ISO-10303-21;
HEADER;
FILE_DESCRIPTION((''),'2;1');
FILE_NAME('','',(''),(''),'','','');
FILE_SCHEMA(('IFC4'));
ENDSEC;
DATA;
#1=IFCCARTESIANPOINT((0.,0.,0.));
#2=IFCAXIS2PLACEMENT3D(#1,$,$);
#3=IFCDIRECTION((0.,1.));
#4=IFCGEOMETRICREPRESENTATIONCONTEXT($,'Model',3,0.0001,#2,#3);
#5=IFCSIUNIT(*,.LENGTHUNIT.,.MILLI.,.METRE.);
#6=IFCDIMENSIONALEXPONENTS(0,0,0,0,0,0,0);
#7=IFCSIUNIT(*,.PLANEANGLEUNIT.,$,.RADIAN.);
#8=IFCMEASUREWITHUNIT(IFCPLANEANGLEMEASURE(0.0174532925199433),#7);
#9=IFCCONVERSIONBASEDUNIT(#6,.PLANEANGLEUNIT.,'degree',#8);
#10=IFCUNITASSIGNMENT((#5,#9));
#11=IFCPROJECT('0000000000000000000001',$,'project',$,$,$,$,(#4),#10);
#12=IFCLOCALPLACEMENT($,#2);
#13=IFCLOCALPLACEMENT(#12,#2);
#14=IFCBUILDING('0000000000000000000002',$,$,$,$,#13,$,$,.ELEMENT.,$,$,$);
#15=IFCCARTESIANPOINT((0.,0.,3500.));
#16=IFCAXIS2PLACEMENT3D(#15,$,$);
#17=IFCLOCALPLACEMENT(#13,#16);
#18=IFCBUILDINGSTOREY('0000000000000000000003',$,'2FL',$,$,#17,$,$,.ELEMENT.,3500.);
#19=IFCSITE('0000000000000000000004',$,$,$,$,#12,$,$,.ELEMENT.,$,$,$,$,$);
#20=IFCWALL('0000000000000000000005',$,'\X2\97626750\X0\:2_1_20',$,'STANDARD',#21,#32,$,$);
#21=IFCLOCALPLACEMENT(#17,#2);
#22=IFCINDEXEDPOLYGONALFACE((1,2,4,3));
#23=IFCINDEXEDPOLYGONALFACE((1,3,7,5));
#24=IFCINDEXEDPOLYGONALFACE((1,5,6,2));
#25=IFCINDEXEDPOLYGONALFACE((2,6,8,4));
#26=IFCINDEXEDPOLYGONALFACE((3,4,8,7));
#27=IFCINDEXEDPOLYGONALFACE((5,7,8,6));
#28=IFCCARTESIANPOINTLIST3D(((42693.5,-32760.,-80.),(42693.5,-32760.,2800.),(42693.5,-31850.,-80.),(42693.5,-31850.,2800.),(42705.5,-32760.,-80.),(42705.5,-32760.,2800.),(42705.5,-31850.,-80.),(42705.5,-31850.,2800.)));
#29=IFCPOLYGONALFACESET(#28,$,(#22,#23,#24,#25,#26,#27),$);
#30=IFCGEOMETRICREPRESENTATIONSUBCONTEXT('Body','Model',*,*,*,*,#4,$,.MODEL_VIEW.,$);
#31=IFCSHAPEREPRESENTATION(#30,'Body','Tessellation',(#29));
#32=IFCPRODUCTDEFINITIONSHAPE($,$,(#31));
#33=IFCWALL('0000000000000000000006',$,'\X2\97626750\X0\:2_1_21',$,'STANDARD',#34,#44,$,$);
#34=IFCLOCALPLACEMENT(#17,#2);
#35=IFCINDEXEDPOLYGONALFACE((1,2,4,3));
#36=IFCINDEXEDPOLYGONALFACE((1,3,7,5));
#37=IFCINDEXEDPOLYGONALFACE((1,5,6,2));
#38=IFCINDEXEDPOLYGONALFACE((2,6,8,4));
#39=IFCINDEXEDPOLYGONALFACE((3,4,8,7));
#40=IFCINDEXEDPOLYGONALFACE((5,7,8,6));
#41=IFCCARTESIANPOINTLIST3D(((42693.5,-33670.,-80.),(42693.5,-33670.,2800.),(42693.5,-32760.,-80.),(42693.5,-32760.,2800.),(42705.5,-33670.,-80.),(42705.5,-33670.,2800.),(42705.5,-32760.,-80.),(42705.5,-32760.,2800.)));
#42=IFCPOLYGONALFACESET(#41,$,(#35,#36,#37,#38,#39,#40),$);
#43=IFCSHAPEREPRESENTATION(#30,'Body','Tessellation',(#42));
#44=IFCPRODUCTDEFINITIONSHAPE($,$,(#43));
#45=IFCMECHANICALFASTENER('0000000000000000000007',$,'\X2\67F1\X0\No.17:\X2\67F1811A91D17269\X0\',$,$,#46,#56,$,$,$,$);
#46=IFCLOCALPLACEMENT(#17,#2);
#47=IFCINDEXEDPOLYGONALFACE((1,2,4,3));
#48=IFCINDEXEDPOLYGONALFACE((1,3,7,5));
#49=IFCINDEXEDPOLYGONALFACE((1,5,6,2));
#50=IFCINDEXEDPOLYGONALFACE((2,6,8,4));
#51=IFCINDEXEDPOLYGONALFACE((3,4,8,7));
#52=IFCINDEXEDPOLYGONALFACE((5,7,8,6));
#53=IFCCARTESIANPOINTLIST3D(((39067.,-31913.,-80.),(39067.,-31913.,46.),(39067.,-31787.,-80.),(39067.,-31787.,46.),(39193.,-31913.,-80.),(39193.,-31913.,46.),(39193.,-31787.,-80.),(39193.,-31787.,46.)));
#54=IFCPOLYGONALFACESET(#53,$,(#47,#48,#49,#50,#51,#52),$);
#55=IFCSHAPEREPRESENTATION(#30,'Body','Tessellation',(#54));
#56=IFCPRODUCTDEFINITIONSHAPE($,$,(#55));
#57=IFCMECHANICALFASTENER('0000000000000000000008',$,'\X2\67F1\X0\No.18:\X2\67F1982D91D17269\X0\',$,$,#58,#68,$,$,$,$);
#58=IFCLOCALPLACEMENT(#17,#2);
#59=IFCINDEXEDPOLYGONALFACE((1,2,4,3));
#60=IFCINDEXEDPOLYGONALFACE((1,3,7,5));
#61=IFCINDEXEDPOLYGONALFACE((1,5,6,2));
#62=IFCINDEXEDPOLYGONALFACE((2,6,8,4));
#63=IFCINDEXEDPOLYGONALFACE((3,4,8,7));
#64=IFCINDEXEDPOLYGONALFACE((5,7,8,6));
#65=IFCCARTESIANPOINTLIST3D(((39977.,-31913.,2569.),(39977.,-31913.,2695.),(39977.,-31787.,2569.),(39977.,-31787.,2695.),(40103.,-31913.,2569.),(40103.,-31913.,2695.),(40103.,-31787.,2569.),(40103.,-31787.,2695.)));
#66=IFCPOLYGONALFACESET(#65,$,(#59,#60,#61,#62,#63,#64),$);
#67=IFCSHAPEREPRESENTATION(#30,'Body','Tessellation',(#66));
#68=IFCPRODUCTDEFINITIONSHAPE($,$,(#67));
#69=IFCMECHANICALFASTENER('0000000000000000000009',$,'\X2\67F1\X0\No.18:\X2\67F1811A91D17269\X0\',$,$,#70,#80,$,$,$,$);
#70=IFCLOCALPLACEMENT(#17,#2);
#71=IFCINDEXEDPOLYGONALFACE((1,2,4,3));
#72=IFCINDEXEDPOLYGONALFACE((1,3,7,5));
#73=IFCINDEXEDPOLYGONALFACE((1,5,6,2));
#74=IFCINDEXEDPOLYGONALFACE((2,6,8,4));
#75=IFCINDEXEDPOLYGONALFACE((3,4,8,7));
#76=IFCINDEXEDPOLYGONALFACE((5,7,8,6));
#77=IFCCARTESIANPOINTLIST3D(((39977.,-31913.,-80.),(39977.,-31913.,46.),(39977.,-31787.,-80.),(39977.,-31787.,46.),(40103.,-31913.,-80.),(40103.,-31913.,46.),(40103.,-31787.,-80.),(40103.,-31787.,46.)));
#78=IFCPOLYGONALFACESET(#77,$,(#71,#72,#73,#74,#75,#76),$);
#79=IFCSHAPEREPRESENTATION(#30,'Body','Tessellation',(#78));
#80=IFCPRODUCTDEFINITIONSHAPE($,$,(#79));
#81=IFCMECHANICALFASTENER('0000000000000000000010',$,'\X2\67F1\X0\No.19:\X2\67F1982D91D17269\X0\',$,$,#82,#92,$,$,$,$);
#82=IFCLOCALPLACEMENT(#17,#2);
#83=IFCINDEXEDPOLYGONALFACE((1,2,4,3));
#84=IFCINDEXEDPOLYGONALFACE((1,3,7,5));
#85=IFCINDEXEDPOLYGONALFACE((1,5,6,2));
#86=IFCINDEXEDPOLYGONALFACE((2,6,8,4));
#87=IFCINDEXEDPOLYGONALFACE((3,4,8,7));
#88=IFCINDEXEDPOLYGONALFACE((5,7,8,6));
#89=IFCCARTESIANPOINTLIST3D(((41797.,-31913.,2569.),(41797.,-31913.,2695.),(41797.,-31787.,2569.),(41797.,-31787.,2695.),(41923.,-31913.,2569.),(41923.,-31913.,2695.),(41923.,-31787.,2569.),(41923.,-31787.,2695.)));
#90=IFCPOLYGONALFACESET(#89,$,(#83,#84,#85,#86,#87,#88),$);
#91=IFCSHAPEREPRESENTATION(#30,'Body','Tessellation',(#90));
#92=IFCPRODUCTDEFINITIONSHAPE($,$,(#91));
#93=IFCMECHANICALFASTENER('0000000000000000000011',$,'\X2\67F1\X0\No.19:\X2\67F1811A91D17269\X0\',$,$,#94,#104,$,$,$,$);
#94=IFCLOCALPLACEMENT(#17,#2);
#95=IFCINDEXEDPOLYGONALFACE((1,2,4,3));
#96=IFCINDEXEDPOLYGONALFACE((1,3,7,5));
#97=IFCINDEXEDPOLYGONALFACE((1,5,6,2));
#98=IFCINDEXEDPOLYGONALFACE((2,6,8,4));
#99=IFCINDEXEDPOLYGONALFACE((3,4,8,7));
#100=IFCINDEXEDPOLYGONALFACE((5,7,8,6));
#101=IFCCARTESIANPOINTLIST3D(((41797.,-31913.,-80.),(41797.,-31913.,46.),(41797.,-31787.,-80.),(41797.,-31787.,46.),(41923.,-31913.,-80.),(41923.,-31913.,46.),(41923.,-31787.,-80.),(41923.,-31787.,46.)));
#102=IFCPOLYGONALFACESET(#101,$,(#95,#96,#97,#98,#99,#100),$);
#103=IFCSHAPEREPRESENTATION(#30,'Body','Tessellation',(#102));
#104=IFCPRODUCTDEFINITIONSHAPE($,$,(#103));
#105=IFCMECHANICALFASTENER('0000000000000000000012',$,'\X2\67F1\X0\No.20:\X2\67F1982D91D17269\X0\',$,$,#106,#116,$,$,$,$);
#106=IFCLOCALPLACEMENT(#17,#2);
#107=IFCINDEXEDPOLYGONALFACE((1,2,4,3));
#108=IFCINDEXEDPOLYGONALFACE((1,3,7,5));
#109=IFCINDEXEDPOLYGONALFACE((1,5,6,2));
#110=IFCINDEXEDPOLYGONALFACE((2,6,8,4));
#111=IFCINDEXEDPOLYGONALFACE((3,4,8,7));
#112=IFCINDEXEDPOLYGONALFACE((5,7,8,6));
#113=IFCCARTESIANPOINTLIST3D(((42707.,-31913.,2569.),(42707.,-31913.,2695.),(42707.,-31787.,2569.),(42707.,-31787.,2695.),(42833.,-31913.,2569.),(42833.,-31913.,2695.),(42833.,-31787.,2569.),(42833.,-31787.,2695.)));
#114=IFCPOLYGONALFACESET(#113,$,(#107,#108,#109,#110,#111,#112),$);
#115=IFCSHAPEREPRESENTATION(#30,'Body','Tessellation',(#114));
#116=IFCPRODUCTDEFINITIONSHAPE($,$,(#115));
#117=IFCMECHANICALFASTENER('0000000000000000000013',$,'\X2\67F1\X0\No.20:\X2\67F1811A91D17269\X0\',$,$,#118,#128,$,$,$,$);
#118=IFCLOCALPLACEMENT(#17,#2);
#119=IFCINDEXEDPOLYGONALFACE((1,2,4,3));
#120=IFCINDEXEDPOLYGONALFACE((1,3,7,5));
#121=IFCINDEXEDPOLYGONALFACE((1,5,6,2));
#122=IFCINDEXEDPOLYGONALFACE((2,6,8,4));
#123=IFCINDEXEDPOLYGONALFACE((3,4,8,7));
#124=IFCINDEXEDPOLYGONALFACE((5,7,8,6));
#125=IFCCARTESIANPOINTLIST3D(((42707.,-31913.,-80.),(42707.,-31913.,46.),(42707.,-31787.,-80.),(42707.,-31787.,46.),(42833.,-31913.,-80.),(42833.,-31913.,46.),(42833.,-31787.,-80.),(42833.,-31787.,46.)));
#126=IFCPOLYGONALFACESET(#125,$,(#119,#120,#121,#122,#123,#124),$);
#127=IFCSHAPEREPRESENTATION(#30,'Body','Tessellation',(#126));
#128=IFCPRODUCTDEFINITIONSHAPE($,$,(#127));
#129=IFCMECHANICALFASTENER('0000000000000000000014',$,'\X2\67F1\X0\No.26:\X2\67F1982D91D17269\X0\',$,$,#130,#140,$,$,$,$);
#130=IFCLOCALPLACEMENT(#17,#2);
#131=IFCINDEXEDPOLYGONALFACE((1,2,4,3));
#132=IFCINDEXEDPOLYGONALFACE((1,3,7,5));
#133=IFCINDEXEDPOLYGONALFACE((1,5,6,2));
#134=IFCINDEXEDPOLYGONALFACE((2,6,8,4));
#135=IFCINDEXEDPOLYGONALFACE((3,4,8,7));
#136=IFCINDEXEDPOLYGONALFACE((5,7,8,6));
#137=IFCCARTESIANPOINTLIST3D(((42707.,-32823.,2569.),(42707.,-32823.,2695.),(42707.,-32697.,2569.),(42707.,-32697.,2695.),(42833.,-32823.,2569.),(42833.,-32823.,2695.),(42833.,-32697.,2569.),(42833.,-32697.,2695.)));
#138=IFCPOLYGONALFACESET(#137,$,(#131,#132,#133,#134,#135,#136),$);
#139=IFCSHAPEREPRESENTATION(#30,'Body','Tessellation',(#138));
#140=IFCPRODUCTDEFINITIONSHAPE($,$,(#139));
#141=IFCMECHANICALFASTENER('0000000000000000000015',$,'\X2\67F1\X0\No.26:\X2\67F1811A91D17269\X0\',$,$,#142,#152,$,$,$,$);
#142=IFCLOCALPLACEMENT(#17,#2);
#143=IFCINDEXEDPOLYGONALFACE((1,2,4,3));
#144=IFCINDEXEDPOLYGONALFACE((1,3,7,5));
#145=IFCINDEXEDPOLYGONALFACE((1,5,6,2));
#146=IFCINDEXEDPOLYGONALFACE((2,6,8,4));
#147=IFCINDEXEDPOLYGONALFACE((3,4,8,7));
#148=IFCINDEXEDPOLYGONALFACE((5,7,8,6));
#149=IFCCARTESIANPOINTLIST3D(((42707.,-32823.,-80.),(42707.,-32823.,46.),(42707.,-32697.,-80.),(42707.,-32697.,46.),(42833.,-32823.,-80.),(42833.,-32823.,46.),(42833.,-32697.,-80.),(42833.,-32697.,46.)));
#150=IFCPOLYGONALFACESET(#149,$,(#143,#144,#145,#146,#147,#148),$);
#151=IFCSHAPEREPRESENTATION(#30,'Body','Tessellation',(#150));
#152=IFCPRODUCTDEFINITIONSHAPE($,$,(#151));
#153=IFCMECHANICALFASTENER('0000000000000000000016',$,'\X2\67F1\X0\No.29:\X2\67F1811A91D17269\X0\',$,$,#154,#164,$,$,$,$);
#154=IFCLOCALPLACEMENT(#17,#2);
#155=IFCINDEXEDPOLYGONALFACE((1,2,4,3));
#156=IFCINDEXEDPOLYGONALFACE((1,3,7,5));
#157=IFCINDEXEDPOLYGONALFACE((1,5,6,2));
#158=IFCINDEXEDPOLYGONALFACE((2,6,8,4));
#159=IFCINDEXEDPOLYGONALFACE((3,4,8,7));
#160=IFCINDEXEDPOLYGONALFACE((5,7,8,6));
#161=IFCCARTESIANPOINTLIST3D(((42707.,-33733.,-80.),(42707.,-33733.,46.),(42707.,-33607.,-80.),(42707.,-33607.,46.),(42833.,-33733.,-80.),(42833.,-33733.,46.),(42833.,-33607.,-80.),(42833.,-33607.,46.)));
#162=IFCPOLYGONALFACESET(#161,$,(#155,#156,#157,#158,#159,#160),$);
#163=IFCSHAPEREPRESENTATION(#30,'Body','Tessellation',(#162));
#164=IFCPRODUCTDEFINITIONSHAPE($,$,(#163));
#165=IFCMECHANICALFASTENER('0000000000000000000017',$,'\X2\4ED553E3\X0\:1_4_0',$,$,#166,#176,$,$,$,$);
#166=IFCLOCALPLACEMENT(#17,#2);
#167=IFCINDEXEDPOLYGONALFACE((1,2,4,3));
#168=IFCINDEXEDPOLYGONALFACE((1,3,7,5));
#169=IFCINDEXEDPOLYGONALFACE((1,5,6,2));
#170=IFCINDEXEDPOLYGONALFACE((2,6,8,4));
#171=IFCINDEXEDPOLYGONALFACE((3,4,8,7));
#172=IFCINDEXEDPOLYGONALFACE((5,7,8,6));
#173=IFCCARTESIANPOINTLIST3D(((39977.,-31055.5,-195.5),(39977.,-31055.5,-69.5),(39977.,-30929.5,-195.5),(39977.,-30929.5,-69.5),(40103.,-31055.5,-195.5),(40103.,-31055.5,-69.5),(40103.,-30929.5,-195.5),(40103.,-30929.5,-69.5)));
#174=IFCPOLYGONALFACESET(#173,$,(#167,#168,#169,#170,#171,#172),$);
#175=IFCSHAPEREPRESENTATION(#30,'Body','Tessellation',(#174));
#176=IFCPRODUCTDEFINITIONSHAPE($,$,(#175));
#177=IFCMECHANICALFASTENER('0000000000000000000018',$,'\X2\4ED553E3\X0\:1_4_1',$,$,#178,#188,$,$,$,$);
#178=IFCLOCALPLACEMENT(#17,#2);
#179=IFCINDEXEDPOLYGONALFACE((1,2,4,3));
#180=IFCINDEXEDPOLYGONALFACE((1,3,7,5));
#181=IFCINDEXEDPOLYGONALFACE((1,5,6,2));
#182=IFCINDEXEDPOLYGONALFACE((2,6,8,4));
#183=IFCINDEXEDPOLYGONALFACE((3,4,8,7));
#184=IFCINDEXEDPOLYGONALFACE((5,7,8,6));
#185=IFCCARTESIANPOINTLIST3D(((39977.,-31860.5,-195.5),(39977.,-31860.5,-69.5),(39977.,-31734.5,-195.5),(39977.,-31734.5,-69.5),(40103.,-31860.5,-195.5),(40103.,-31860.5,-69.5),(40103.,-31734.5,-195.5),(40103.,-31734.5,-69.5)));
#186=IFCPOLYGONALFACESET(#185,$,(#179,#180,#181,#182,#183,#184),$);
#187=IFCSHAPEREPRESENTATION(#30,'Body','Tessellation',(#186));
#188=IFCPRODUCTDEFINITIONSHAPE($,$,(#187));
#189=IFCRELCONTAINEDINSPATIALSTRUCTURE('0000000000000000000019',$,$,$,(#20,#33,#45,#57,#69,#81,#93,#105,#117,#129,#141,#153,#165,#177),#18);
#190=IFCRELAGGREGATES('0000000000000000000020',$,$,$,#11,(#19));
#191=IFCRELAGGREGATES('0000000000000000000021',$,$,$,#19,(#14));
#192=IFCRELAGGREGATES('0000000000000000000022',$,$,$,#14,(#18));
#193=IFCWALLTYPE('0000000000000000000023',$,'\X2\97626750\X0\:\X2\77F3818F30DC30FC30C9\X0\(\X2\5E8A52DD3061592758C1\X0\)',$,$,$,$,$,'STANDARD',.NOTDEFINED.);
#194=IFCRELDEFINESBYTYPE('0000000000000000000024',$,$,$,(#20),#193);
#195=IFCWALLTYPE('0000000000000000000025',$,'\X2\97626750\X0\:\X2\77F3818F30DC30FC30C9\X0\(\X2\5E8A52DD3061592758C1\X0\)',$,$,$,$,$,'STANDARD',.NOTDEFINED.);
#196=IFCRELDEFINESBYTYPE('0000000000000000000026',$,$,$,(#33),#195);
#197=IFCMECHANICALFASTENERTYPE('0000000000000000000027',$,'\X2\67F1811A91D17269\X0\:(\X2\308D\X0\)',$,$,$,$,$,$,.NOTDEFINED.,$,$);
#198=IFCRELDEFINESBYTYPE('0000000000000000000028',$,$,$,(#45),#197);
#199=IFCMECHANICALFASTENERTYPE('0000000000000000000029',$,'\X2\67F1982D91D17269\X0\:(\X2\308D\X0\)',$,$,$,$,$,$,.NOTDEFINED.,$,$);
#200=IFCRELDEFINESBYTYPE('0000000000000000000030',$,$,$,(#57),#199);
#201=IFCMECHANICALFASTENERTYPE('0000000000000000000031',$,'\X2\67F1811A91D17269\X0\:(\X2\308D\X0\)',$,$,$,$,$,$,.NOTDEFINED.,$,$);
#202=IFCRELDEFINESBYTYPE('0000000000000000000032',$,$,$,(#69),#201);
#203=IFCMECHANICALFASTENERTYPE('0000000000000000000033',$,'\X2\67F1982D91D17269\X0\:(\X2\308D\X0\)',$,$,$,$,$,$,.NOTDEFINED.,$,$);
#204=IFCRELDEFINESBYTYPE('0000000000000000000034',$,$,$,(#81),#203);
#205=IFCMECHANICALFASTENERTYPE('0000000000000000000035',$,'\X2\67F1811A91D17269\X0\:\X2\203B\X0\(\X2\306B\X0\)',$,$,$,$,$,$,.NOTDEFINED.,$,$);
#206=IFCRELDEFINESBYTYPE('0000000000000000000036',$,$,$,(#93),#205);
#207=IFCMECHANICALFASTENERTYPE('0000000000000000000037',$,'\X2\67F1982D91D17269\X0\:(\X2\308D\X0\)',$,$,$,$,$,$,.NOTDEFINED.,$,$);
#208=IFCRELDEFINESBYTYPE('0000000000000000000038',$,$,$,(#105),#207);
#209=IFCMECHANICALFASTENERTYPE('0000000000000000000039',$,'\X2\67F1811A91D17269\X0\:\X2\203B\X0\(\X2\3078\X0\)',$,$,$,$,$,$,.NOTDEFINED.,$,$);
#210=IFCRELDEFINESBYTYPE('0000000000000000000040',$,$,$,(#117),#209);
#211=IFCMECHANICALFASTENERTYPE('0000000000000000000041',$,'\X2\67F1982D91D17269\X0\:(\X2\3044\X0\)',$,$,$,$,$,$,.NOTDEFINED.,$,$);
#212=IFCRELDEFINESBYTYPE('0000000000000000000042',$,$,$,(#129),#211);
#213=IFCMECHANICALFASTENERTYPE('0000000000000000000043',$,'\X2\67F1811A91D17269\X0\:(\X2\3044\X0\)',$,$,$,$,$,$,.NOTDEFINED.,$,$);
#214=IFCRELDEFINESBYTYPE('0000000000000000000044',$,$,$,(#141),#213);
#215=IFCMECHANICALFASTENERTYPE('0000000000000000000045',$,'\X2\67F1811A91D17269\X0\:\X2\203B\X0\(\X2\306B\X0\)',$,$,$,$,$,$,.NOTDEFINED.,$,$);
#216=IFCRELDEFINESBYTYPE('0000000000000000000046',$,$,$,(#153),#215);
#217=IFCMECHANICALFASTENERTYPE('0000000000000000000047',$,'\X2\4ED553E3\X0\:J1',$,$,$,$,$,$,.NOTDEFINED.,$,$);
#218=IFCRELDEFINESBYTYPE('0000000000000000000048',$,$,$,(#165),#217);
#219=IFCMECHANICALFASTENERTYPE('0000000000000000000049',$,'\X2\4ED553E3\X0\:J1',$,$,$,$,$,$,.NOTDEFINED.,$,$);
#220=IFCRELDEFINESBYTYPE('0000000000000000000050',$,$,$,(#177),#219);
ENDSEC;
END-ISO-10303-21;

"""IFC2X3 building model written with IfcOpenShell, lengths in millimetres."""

from ifc_helpers import new_model, entity, si_unit, converted_unit, direction, frame, origin, origin_with_axes, origin_2d, place, context, subcontext, project, spatial, polyline, rectangle, outline, extrude, type_object, element, save


model = new_model("IFC2X3")

# Units and contexts
model_context = context("Model", 3, precision=0.0001, world=origin(), true_north=direction((0.0, 1.0)))
body_context = subcontext(model_context, "Body", "Model", "MODEL_VIEW")
ifc_project = project(units=[si_unit("LENGTHUNIT", "METRE", prefix="MILLI"), converted_unit("PLANEANGLEUNIT", "degree", entity("IfcPlaneAngleMeasure", 0.0174532925199433), si_unit("PLANEANGLEUNIT", "RADIAN"), dimensions=[0, 0, 0, 0, 0, 0, 0])], contexts=[model_context])

# Site, building, storey
site_placement = place(None, origin())
site = spatial("IfcSite", under=ifc_project, at=site_placement, CompositionType="ELEMENT")
building_placement = place(site_placement, origin())
building = spatial("IfcBuilding", under=site, at=building_placement, CompositionType="ELEMENT")
storey_placement = place(building_placement, frame((0.0, 0.0, 3500.0)))
storey = spatial("IfcBuildingStorey", under=building, at=storey_placement, Name="2FL", CompositionType="ELEMENT", Elevation=3500.0)

# Walls
wall_type_1 = type_object("IfcWallType", Name="面材:石膏ボード(床勝ち大壁)", ElementType="STANDARD", PredefinedType="NOTDEFINED")
wall_1_placement = place(storey_placement, frame((42705.5, -32305.0, -80.0), z_axis=(-1.0, 0.0, 0.0), x_axis=(0.0, -1.0, 0.0)))
element("IfcWall", 1, at=wall_1_placement, inside=storey, type_object=wall_type_1, Name="面材:2_1_20", ObjectType="STANDARD", context=body_context, shape_type="SweptSolid", body=[
    extrude(outline(polyline([(455.0, 0.0, 0.0), (-455.0, 0.0, 0.0), (-455.0, 2880.0, 0.0), (455.0, 2880.0, 0.0), (455.0, 0.0, 0.0)])), origin_with_axes(), (0.0, 0.0, 1.0), 12.0),
])
wall_type_2 = type_object("IfcWallType", Name="面材:石膏ボード(床勝ち大壁)", ElementType="STANDARD", PredefinedType="NOTDEFINED")
wall_2_placement = place(storey_placement, frame((42705.5, -33215.0, -80.0), z_axis=(-1.0, 0.0, 0.0), x_axis=(0.0, -1.0, 0.0)))
element("IfcWall", 2, at=wall_2_placement, inside=storey, type_object=wall_type_2, Name="面材:2_1_21", ObjectType="STANDARD", context=body_context, shape_type="SweptSolid", body=[
    extrude(outline(polyline([(455.0, 0.0, 0.0), (-455.0, 0.0, 0.0), (-455.0, 2880.0, 0.0), (455.0, 2880.0, 0.0), (455.0, 0.0, 0.0)])), origin_with_axes(), (0.0, 0.0, 1.0), 12.0),
])

# Mechanical fasteners
mechanical_fastener_type_1 = type_object("IfcMechanicalFastenerType", Name="柱脚金物:(ろ)")
mechanical_fastener_1_placement = place(storey_placement, frame((39130.0, -31850.0, -80.0)))
element("IfcMechanicalFastener", 3, at=mechanical_fastener_1_placement, inside=storey, type_object=mechanical_fastener_type_1, Name="柱No.17:柱脚金物", context=body_context, shape_type="SweptSolid", body=[
    extrude(rectangle(XDim=126.0, YDim=126.0, at=origin_2d()), origin_with_axes(), (0.0, 0.0, 1.0), 126.0),
])
mechanical_fastener_type_2 = type_object("IfcMechanicalFastenerType", Name="柱頭金物:(ろ)")
mechanical_fastener_2_placement = place(storey_placement, frame((40040.0, -31850.0, 2569.0)))
element("IfcMechanicalFastener", 4, at=mechanical_fastener_2_placement, inside=storey, type_object=mechanical_fastener_type_2, Name="柱No.18:柱頭金物", context=body_context, shape_type="SweptSolid", body=[
    extrude(rectangle(XDim=126.0, YDim=126.0, at=origin_2d()), origin_with_axes(), (0.0, 0.0, 1.0), 126.0),
])
mechanical_fastener_type_3 = type_object("IfcMechanicalFastenerType", Name="柱脚金物:(ろ)")
mechanical_fastener_3_placement = place(storey_placement, frame((40040.0, -31850.0, -80.0)))
element("IfcMechanicalFastener", 5, at=mechanical_fastener_3_placement, inside=storey, type_object=mechanical_fastener_type_3, Name="柱No.18:柱脚金物", context=body_context, shape_type="SweptSolid", body=[
    extrude(rectangle(XDim=126.0, YDim=126.0, at=origin_2d()), origin_with_axes(), (0.0, 0.0, 1.0), 126.0),
])
mechanical_fastener_type_4 = type_object("IfcMechanicalFastenerType", Name="柱頭金物:(ろ)")
mechanical_fastener_4_placement = place(storey_placement, frame((41860.0, -31850.0, 2569.0)))
element("IfcMechanicalFastener", 6, at=mechanical_fastener_4_placement, inside=storey, type_object=mechanical_fastener_type_4, Name="柱No.19:柱頭金物", context=body_context, shape_type="SweptSolid", body=[
    extrude(rectangle(XDim=126.0, YDim=126.0, at=origin_2d()), origin_with_axes(), (0.0, 0.0, 1.0), 126.0),
])
mechanical_fastener_type_5 = type_object("IfcMechanicalFastenerType", Name="柱脚金物:※(に)")
mechanical_fastener_5_placement = place(storey_placement, frame((41860.0, -31850.0, -80.0)))
element("IfcMechanicalFastener", 7, at=mechanical_fastener_5_placement, inside=storey, type_object=mechanical_fastener_type_5, Name="柱No.19:柱脚金物", context=body_context, shape_type="SweptSolid", body=[
    extrude(rectangle(XDim=126.0, YDim=126.0, at=origin_2d()), origin_with_axes(), (0.0, 0.0, 1.0), 126.0),
])
mechanical_fastener_type_6 = type_object("IfcMechanicalFastenerType", Name="柱頭金物:(ろ)")
mechanical_fastener_6_placement = place(storey_placement, frame((42770.0, -31850.0, 2569.0)))
element("IfcMechanicalFastener", 8, at=mechanical_fastener_6_placement, inside=storey, type_object=mechanical_fastener_type_6, Name="柱No.20:柱頭金物", context=body_context, shape_type="SweptSolid", body=[
    extrude(rectangle(XDim=126.0, YDim=126.0, at=origin_2d()), origin_with_axes(), (0.0, 0.0, 1.0), 126.0),
])
mechanical_fastener_type_7 = type_object("IfcMechanicalFastenerType", Name="柱脚金物:※(へ)")
mechanical_fastener_7_placement = place(storey_placement, frame((42770.0, -31850.0, -80.0)))
element("IfcMechanicalFastener", 9, at=mechanical_fastener_7_placement, inside=storey, type_object=mechanical_fastener_type_7, Name="柱No.20:柱脚金物", context=body_context, shape_type="SweptSolid", body=[
    extrude(rectangle(XDim=126.0, YDim=126.0, at=origin_2d()), origin_with_axes(), (0.0, 0.0, 1.0), 126.0),
])
mechanical_fastener_type_8 = type_object("IfcMechanicalFastenerType", Name="柱頭金物:(い)")
mechanical_fastener_8_placement = place(storey_placement, frame((42770.0, -32760.0, 2569.0)))
element("IfcMechanicalFastener", 10, at=mechanical_fastener_8_placement, inside=storey, type_object=mechanical_fastener_type_8, Name="柱No.26:柱頭金物", context=body_context, shape_type="SweptSolid", body=[
    extrude(rectangle(XDim=126.0, YDim=126.0, at=origin_2d()), origin_with_axes(), (0.0, 0.0, 1.0), 126.0),
])
mechanical_fastener_type_9 = type_object("IfcMechanicalFastenerType", Name="柱脚金物:(い)")
mechanical_fastener_9_placement = place(storey_placement, frame((42770.0, -32760.0, -80.0)))
element("IfcMechanicalFastener", 11, at=mechanical_fastener_9_placement, inside=storey, type_object=mechanical_fastener_type_9, Name="柱No.26:柱脚金物", context=body_context, shape_type="SweptSolid", body=[
    extrude(rectangle(XDim=126.0, YDim=126.0, at=origin_2d()), origin_with_axes(), (0.0, 0.0, 1.0), 126.0),
])
mechanical_fastener_type_10 = type_object("IfcMechanicalFastenerType", Name="柱脚金物:※(に)")
mechanical_fastener_10_placement = place(storey_placement, frame((42770.0, -33670.0, -80.0)))
element("IfcMechanicalFastener", 12, at=mechanical_fastener_10_placement, inside=storey, type_object=mechanical_fastener_type_10, Name="柱No.29:柱脚金物", context=body_context, shape_type="SweptSolid", body=[
    extrude(rectangle(XDim=126.0, YDim=126.0, at=origin_2d()), origin_with_axes(), (0.0, 0.0, 1.0), 126.0),
])
mechanical_fastener_type_11 = type_object("IfcMechanicalFastenerType", Name="仕口:J1")
mechanical_fastener_11_placement = place(storey_placement, frame((40040.0, -30992.5, -195.5)))
element("IfcMechanicalFastener", 13, at=mechanical_fastener_11_placement, inside=storey, type_object=mechanical_fastener_type_11, Name="仕口:1_4_0", context=body_context, shape_type="SweptSolid", body=[
    extrude(rectangle(XDim=126.0, YDim=126.0, at=origin_2d()), origin_with_axes(), (0.0, 0.0, 1.0), 126.0),
])
mechanical_fastener_type_12 = type_object("IfcMechanicalFastenerType", Name="仕口:J1")
mechanical_fastener_12_placement = place(storey_placement, frame((40040.0, -31797.5, -195.5)))
element("IfcMechanicalFastener", 14, at=mechanical_fastener_12_placement, inside=storey, type_object=mechanical_fastener_type_12, Name="仕口:1_4_1", context=body_context, shape_type="SweptSolid", body=[
    extrude(rectangle(XDim=126.0, YDim=126.0, at=origin_2d()), origin_with_axes(), (0.0, 0.0, 1.0), 126.0),
])

save(model, "model.ifc")
